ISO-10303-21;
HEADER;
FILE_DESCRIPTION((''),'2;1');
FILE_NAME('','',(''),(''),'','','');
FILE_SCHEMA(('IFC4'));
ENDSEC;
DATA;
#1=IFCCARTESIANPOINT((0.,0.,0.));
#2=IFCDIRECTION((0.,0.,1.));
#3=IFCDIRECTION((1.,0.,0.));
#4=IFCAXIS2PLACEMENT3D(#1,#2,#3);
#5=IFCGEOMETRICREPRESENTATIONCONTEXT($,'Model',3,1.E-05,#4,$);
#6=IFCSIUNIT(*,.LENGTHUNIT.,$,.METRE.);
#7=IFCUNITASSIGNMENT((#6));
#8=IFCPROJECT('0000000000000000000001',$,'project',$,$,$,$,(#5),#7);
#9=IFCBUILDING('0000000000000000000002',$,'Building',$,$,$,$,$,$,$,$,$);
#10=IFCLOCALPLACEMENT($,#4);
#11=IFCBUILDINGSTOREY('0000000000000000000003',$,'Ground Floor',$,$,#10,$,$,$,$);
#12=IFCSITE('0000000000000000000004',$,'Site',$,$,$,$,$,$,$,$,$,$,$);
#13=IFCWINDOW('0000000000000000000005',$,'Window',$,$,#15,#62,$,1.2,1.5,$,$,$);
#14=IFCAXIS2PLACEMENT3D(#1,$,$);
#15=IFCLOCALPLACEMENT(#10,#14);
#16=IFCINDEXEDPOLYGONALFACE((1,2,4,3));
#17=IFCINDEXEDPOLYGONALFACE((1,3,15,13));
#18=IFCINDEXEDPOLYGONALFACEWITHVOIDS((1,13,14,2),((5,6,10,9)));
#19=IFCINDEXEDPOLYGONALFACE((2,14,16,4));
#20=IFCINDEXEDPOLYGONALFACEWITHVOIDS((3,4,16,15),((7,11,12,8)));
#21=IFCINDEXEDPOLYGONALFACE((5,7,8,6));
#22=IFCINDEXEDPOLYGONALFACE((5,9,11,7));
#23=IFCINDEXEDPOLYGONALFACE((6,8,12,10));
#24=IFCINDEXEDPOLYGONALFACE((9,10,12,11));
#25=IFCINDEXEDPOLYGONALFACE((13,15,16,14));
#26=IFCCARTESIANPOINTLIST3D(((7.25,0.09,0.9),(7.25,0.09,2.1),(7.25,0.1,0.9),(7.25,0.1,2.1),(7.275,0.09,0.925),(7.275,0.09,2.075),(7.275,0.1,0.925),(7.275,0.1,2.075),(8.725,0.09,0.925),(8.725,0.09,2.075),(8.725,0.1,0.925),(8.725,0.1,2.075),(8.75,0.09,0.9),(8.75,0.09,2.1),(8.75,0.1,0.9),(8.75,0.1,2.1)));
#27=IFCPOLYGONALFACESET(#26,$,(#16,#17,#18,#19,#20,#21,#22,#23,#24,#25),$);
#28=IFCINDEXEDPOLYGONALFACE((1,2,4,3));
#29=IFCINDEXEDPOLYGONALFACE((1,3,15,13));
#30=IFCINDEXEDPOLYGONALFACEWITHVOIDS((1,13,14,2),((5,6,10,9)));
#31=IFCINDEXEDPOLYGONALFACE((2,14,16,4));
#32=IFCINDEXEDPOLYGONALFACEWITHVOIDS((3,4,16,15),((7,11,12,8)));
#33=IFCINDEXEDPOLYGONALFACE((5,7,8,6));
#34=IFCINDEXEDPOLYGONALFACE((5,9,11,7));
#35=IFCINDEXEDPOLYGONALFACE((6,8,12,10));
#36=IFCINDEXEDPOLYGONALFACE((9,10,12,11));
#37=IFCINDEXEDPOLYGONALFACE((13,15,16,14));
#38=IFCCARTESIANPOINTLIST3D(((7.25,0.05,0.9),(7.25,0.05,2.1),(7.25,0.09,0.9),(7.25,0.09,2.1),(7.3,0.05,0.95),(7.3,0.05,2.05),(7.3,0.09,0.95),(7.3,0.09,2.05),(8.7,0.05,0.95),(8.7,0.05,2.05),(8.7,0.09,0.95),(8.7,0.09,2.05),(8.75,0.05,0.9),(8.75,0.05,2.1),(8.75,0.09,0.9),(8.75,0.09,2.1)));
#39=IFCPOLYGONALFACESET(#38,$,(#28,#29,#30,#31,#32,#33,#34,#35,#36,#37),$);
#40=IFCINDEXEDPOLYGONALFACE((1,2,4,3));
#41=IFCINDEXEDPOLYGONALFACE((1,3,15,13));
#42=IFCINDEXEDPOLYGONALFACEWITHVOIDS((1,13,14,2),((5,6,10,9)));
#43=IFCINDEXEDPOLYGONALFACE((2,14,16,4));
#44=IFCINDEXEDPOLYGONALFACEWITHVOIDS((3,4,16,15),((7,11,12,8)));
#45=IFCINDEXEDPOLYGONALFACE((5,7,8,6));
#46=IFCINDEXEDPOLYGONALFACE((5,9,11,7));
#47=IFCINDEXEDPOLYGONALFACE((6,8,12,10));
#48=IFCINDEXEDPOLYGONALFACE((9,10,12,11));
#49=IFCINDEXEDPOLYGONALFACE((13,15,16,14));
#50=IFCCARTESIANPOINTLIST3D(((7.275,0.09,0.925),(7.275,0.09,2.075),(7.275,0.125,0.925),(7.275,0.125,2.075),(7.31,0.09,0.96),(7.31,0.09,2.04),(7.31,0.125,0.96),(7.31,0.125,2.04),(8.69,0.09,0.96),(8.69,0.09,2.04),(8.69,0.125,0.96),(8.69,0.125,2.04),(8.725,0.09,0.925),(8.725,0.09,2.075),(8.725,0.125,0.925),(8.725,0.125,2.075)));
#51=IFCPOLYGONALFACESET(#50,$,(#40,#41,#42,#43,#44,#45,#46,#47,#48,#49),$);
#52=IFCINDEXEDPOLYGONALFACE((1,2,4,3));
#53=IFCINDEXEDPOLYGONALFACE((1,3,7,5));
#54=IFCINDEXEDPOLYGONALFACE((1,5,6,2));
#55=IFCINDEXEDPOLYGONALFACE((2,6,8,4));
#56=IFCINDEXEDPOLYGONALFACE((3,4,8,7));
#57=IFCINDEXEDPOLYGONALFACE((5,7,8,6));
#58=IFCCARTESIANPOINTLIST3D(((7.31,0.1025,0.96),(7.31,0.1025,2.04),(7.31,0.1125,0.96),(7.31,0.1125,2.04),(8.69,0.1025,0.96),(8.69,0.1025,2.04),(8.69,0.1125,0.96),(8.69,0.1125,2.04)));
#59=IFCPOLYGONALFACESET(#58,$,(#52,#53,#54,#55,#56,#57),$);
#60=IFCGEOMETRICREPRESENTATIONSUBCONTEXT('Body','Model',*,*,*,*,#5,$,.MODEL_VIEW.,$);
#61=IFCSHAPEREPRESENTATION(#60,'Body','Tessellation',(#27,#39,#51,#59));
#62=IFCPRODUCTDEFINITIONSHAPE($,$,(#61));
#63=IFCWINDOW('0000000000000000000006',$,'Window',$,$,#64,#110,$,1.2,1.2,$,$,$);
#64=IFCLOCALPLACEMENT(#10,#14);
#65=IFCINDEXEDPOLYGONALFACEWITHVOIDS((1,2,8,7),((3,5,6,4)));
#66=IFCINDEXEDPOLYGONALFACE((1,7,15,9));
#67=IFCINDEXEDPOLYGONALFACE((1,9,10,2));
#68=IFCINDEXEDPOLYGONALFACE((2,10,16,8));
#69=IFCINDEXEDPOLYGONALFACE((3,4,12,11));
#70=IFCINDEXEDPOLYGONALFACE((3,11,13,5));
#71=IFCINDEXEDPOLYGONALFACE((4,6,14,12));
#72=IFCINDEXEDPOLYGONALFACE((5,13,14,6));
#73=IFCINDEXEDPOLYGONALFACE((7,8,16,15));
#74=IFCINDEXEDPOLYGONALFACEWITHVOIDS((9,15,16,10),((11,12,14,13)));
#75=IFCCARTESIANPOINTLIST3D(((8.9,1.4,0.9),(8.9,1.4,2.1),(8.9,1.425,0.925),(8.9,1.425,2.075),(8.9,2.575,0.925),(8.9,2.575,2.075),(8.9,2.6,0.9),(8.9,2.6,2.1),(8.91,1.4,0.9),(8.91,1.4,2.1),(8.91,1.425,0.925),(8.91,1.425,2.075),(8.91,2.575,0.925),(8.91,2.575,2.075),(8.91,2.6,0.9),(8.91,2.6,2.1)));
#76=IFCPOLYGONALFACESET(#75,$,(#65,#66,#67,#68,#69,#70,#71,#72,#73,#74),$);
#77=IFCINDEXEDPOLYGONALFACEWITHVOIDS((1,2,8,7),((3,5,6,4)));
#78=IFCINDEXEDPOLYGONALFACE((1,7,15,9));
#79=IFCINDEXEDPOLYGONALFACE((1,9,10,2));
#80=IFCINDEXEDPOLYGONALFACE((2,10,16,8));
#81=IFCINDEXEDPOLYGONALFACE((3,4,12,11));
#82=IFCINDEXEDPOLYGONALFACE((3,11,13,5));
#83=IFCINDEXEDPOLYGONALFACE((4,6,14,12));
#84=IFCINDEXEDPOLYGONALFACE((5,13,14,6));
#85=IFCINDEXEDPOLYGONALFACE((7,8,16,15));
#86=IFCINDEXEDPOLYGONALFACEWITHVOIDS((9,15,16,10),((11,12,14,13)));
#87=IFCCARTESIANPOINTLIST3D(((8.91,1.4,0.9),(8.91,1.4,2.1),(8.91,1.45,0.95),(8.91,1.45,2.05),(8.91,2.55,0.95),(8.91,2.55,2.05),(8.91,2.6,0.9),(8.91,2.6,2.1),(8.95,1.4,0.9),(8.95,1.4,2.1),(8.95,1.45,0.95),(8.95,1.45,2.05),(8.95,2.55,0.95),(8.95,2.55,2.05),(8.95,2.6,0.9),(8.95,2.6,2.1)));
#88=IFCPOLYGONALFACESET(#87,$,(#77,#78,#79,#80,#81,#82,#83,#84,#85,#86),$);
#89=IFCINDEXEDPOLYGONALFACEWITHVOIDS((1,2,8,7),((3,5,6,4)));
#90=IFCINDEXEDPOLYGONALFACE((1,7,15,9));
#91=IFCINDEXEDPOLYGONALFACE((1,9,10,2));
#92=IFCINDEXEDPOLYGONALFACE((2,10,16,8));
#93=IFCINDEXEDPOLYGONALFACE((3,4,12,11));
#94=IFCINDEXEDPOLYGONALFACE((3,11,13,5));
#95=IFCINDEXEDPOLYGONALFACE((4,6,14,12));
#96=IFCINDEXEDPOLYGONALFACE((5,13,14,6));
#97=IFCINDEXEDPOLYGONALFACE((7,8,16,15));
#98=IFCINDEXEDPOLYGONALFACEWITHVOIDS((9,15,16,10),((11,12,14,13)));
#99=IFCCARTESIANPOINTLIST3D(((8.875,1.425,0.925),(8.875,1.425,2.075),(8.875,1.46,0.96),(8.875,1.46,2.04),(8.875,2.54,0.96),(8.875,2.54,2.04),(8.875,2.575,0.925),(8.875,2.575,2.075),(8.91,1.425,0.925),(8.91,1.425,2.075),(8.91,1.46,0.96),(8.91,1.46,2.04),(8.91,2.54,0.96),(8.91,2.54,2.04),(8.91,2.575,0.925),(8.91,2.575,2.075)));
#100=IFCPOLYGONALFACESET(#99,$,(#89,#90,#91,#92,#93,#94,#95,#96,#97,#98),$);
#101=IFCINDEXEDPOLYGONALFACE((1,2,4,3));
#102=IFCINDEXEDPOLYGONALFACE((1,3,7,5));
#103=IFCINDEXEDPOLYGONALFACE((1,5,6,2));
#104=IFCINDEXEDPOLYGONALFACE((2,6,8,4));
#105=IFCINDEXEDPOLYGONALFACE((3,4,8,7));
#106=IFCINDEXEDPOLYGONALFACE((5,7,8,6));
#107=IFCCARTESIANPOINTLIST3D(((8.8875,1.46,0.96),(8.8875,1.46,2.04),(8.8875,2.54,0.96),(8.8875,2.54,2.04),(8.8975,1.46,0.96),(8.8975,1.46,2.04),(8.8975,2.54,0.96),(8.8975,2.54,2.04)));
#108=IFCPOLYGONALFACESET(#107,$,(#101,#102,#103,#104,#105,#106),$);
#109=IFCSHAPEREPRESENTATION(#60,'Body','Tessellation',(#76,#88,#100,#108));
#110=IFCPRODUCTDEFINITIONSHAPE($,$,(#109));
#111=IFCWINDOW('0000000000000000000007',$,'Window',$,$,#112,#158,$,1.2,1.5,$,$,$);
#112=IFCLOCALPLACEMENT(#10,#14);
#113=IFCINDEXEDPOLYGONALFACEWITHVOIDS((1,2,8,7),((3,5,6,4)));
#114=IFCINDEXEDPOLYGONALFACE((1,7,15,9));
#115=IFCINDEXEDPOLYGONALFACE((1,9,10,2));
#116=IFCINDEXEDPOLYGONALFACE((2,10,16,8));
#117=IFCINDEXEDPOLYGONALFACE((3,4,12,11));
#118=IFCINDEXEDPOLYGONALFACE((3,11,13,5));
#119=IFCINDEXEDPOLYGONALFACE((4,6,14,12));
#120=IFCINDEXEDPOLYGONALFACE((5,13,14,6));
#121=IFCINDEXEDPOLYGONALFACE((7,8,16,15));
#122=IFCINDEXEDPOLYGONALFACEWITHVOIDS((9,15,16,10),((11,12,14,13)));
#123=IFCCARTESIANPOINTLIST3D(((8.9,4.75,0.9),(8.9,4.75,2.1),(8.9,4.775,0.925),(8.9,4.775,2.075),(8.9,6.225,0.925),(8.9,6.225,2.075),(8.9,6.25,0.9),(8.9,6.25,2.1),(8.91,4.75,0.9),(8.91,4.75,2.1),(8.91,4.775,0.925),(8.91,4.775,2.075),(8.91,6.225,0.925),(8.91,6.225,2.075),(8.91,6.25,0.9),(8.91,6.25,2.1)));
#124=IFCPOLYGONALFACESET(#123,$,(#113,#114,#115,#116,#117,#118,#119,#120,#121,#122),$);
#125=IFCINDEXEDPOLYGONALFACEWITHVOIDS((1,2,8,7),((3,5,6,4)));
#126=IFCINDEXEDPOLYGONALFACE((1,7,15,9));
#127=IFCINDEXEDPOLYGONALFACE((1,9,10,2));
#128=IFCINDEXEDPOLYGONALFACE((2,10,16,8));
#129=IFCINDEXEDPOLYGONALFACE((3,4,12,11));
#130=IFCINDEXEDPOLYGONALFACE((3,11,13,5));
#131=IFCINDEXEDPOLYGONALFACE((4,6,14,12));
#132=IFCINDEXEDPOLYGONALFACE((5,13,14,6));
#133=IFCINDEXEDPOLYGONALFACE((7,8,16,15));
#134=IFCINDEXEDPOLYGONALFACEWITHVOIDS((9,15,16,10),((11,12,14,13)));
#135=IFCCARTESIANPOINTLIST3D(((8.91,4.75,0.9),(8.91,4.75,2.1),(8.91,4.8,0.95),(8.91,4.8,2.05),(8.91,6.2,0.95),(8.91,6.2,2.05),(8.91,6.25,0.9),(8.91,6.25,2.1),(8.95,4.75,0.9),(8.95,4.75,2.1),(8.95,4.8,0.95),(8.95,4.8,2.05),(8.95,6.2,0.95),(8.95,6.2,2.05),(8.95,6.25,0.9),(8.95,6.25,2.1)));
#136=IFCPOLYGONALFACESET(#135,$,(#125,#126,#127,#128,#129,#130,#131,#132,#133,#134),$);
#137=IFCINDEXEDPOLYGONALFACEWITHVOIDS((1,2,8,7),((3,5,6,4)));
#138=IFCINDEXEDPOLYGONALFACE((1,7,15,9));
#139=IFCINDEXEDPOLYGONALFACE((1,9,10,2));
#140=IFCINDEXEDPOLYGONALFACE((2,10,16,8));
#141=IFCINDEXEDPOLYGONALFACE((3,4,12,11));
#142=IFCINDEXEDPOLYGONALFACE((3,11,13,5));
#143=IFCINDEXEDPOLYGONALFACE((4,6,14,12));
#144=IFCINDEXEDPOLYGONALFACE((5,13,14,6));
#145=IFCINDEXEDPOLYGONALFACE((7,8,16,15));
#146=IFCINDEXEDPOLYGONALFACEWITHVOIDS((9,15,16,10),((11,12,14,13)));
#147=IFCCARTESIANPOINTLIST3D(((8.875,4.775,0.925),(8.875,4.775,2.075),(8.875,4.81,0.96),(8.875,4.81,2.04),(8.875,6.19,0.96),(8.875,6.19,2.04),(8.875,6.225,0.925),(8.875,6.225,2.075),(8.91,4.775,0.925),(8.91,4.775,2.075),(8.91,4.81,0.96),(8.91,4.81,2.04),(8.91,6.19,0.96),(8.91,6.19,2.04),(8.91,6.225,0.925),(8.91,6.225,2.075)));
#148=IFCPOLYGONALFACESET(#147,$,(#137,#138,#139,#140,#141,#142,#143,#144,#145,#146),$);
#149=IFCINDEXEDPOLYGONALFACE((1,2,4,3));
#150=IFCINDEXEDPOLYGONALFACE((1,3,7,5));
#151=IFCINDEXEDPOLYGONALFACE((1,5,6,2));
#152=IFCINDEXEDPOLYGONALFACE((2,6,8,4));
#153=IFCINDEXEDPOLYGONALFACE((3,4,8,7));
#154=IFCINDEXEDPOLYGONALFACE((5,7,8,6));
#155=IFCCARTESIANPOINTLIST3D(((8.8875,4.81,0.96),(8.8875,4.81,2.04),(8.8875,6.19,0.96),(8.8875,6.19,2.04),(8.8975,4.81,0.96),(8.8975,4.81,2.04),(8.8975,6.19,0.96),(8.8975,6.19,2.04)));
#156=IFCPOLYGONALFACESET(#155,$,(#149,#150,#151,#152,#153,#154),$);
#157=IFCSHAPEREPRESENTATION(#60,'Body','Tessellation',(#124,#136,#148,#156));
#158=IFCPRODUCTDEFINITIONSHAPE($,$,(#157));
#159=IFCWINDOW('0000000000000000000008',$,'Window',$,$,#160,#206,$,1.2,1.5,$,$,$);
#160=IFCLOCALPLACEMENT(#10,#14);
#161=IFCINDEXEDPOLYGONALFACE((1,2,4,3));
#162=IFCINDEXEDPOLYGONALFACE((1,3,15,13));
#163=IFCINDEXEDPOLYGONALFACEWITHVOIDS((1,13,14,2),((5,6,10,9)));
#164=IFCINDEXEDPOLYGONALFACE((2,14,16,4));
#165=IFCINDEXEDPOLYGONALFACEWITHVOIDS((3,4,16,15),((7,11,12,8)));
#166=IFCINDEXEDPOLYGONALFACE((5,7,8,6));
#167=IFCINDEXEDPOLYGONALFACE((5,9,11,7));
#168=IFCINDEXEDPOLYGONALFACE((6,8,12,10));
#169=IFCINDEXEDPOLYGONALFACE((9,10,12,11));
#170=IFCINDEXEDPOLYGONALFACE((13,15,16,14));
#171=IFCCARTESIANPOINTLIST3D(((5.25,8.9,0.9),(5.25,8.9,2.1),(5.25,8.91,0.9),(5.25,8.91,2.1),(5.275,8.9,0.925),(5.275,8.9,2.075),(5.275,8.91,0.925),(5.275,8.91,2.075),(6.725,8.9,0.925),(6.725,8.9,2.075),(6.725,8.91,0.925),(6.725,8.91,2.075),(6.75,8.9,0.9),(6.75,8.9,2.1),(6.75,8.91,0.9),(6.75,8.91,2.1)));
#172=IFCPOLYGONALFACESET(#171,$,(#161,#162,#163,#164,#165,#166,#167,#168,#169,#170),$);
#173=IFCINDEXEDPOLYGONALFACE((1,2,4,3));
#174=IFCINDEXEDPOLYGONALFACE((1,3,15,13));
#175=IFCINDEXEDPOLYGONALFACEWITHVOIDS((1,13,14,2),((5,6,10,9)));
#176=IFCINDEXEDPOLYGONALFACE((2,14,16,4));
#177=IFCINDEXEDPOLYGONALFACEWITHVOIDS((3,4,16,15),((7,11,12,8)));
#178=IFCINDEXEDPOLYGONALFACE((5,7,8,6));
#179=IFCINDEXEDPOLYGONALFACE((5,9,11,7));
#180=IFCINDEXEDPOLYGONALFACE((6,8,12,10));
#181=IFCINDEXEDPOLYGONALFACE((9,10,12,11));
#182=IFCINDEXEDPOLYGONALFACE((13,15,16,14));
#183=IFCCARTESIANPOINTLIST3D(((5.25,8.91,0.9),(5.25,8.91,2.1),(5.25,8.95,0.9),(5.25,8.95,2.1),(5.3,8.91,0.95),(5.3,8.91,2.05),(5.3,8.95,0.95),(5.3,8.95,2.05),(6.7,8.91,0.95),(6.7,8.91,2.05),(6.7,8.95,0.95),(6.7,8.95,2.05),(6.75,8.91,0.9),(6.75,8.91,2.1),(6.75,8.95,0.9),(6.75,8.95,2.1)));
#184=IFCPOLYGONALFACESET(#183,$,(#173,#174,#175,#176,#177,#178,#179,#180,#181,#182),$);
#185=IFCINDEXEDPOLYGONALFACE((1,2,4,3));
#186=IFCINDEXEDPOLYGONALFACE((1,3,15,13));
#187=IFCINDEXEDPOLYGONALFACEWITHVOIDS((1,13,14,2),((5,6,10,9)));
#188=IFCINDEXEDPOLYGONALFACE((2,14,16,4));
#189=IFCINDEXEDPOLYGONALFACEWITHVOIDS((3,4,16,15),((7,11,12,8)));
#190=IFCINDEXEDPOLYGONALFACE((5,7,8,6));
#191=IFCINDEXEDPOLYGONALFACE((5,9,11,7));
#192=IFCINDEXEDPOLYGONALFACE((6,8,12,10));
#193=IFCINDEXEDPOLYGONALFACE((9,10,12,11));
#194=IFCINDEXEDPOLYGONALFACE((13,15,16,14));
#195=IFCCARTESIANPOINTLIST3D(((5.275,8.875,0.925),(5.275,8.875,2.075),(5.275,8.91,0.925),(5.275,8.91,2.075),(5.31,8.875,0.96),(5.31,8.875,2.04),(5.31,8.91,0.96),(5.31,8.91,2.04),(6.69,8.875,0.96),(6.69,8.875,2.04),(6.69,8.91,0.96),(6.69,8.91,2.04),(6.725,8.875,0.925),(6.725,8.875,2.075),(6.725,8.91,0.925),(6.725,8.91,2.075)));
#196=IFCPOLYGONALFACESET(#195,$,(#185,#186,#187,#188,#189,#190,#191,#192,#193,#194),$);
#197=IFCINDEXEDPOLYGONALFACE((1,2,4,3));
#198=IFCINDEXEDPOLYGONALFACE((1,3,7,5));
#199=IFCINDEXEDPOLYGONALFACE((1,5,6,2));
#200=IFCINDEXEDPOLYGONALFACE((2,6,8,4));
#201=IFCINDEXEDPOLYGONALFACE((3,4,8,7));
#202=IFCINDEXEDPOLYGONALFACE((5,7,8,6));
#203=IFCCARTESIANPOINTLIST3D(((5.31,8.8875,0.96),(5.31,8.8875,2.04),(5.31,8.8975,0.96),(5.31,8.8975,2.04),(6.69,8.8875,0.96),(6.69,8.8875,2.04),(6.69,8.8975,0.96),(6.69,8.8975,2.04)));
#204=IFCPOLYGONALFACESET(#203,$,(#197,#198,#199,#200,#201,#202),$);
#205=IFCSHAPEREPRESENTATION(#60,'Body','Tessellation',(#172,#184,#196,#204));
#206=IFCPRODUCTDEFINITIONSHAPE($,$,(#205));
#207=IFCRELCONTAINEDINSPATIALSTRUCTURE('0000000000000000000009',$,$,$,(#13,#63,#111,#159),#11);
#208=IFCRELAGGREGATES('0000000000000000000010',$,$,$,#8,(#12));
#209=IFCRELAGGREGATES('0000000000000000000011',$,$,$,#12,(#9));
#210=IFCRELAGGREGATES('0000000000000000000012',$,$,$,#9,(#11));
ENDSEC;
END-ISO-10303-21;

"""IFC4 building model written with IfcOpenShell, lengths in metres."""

from ifc_helpers import new_model, si_unit, frame, origin_with_axes, place, context, subcontext, project, spatial, line, indexed_curve, outline, extrude, element, save


model = new_model("IFC4")

# Units and contexts
model_context = context("Model", 3, precision=1e-05, world=origin_with_axes())
body_context = subcontext(model_context, "Body", "Model", "MODEL_VIEW")
ifc_project = project(units=[si_unit("LENGTHUNIT", "METRE")], contexts=[model_context])

# Site, building, storey
site = spatial("IfcSite", under=ifc_project, Name="Site")
building = spatial("IfcBuilding", under=site, Name="Building")
storey_placement = place(None, origin_with_axes())
storey = spatial("IfcBuildingStorey", under=building, at=storey_placement, Name="Ground Floor")

# Windows
window_1_placement = place(storey_placement, frame((7.25, 0.0, 0.9), z_axis=(0.0, 0.0, 1.0), x_axis=(1.0, 0.0, 0.0)))
element("IfcWindow", 1, at=window_1_placement, inside=storey, Name="Window", OverallHeight=1.2, OverallWidth=1.5, context=body_context, shape_type="SweptSolid", body=[
    extrude(outline(indexed_curve([(0.0, 0.0), (1.5, 0.0), (1.5, 1.2), (0.0, 1.2)], segments=[line(1, 2, 3, 4, 1)]), holes=[indexed_curve([(0.025, 0.025), (1.475, 0.025), (1.475, 1.175), (0.025, 1.175)], segments=[line(1, 2, 3, 4, 1)])]), frame((0.0, 0.09, 0.0), z_axis=(0.0, -1.0, 0.0), x_axis=(1.0, 0.0, 0.0)), (0.0, 0.0, -1.0), 0.01),
    extrude(outline(indexed_curve([(0.0, 0.0), (1.5, 0.0), (1.5, 1.2), (0.0, 1.2)], segments=[line(1, 2, 3, 4, 1)]), holes=[indexed_curve([(0.05, 0.05), (1.45, 0.05), (1.45, 1.15), (0.05, 1.15)], segments=[line(1, 2, 3, 4, 1)])]), frame((0.0, 0.05, 0.0), z_axis=(0.0, -1.0, 0.0), x_axis=(1.0, 0.0, 0.0)), (0.0, 0.0, -1.0), 0.04),
    extrude(outline(indexed_curve([(0.0, 0.0), (1.45, 0.0), (1.45, 1.15), (0.0, 1.15)], segments=[line(1, 2, 3, 4, 1)]), holes=[indexed_curve([(0.035, 0.035), (1.415, 0.035), (1.415, 1.115), (0.035, 1.115)], segments=[line(1, 2, 3, 4, 1)])]), frame((0.025, 0.09, 0.025), z_axis=(0.0, -1.0, 0.0), x_axis=(1.0, 0.0, 0.0)), (0.0, 0.0, -1.0), 0.035),
    extrude(outline(indexed_curve([(0.035, 0.035), (1.415, 0.035), (1.415, 1.115), (0.035, 1.115)], segments=[line(1, 2, 3, 4, 1)])), frame((0.025, 0.1025, 0.025), z_axis=(0.0, -1.0, 0.0), x_axis=(1.0, 0.0, 0.0)), (0.0, 0.0, -1.0), 0.01),
])
window_2_placement = place(storey_placement, frame((9.0, 1.4, 0.9), z_axis=(0.0, 0.0, 1.0), x_axis=(0.0, 1.0, 0.0)))
element("IfcWindow", 2, at=window_2_placement, inside=storey, Name="Window", OverallHeight=1.2, OverallWidth=1.2, context=body_context, shape_type="SweptSolid", body=[
    extrude(outline(indexed_curve([(0.0, 0.0), (1.2, 0.0), (1.2, 1.2), (0.0, 1.2)], segments=[line(1, 2, 3, 4, 1)]), holes=[indexed_curve([(0.025, 0.025), (1.175, 0.025), (1.175, 1.175), (0.025, 1.175)], segments=[line(1, 2, 3, 4, 1)])]), frame((0.0, 0.09, 0.0), z_axis=(0.0, -1.0, 0.0), x_axis=(1.0, 0.0, 0.0)), (0.0, 0.0, -1.0), 0.01),
    extrude(outline(indexed_curve([(0.0, 0.0), (1.2, 0.0), (1.2, 1.2), (0.0, 1.2)], segments=[line(1, 2, 3, 4, 1)]), holes=[indexed_curve([(0.05, 0.05), (1.15, 0.05), (1.15, 1.15), (0.05, 1.15)], segments=[line(1, 2, 3, 4, 1)])]), frame((0.0, 0.05, 0.0), z_axis=(0.0, -1.0, 0.0), x_axis=(1.0, 0.0, 0.0)), (0.0, 0.0, -1.0), 0.04),
    extrude(outline(indexed_curve([(0.0, 0.0), (1.15, 0.0), (1.15, 1.15), (0.0, 1.15)], segments=[line(1, 2, 3, 4, 1)]), holes=[indexed_curve([(0.035, 0.035), (1.115, 0.035), (1.115, 1.115), (0.035, 1.115)], segments=[line(1, 2, 3, 4, 1)])]), frame((0.025, 0.09, 0.025), z_axis=(0.0, -1.0, 0.0), x_axis=(1.0, 0.0, 0.0)), (0.0, 0.0, -1.0), 0.035),
    extrude(outline(indexed_curve([(0.035, 0.035), (1.115, 0.035), (1.115, 1.115), (0.035, 1.115)], segments=[line(1, 2, 3, 4, 1)])), frame((0.025, 0.1025, 0.025), z_axis=(0.0, -1.0, 0.0), x_axis=(1.0, 0.0, 0.0)), (0.0, 0.0, -1.0), 0.01),
])
for number, where, z_axis, x_axis, name in (
    (3, (9.0, 4.75, 0.9), (0.0, 0.0, 1.0), (0.0, 1.0, 0.0), "Window"),
    (4, (6.75, 9.0, 0.9), (0.0, 0.0, 1.0), (-1.0, 0.0, 0.0), "Window"),
):
    element("IfcWindow", number, at=place(storey_placement, frame(where, z_axis=z_axis, x_axis=x_axis)), inside=storey, Name=name, OverallHeight=1.2, OverallWidth=1.5, context=body_context, shape_type="SweptSolid", body=[
        extrude(outline(indexed_curve([(0.0, 0.0), (1.5, 0.0), (1.5, 1.2), (0.0, 1.2)], segments=[line(1, 2, 3, 4, 1)]), holes=[indexed_curve([(0.025, 0.025), (1.475, 0.025), (1.475, 1.175), (0.025, 1.175)], segments=[line(1, 2, 3, 4, 1)])]), frame((0.0, 0.09, 0.0), z_axis=(0.0, -1.0, 0.0), x_axis=(1.0, 0.0, 0.0)), (0.0, 0.0, -1.0), 0.01),
        extrude(outline(indexed_curve([(0.0, 0.0), (1.5, 0.0), (1.5, 1.2), (0.0, 1.2)], segments=[line(1, 2, 3, 4, 1)]), holes=[indexed_curve([(0.05, 0.05), (1.45, 0.05), (1.45, 1.15), (0.05, 1.15)], segments=[line(1, 2, 3, 4, 1)])]), frame((0.0, 0.05, 0.0), z_axis=(0.0, -1.0, 0.0), x_axis=(1.0, 0.0, 0.0)), (0.0, 0.0, -1.0), 0.04),
        extrude(outline(indexed_curve([(0.0, 0.0), (1.45, 0.0), (1.45, 1.15), (0.0, 1.15)], segments=[line(1, 2, 3, 4, 1)]), holes=[indexed_curve([(0.035, 0.035), (1.415, 0.035), (1.415, 1.115), (0.035, 1.115)], segments=[line(1, 2, 3, 4, 1)])]), frame((0.025, 0.09, 0.025), z_axis=(0.0, -1.0, 0.0), x_axis=(1.0, 0.0, 0.0)), (0.0, 0.0, -1.0), 0.035),
        extrude(outline(indexed_curve([(0.035, 0.035), (1.415, 0.035), (1.415, 1.115), (0.035, 1.115)], segments=[line(1, 2, 3, 4, 1)])), frame((0.025, 0.1025, 0.025), z_axis=(0.0, -1.0, 0.0), x_axis=(1.0, 0.0, 0.0)), (0.0, 0.0, -1.0), 0.01),
    ])

save(model, "model.ifc")
